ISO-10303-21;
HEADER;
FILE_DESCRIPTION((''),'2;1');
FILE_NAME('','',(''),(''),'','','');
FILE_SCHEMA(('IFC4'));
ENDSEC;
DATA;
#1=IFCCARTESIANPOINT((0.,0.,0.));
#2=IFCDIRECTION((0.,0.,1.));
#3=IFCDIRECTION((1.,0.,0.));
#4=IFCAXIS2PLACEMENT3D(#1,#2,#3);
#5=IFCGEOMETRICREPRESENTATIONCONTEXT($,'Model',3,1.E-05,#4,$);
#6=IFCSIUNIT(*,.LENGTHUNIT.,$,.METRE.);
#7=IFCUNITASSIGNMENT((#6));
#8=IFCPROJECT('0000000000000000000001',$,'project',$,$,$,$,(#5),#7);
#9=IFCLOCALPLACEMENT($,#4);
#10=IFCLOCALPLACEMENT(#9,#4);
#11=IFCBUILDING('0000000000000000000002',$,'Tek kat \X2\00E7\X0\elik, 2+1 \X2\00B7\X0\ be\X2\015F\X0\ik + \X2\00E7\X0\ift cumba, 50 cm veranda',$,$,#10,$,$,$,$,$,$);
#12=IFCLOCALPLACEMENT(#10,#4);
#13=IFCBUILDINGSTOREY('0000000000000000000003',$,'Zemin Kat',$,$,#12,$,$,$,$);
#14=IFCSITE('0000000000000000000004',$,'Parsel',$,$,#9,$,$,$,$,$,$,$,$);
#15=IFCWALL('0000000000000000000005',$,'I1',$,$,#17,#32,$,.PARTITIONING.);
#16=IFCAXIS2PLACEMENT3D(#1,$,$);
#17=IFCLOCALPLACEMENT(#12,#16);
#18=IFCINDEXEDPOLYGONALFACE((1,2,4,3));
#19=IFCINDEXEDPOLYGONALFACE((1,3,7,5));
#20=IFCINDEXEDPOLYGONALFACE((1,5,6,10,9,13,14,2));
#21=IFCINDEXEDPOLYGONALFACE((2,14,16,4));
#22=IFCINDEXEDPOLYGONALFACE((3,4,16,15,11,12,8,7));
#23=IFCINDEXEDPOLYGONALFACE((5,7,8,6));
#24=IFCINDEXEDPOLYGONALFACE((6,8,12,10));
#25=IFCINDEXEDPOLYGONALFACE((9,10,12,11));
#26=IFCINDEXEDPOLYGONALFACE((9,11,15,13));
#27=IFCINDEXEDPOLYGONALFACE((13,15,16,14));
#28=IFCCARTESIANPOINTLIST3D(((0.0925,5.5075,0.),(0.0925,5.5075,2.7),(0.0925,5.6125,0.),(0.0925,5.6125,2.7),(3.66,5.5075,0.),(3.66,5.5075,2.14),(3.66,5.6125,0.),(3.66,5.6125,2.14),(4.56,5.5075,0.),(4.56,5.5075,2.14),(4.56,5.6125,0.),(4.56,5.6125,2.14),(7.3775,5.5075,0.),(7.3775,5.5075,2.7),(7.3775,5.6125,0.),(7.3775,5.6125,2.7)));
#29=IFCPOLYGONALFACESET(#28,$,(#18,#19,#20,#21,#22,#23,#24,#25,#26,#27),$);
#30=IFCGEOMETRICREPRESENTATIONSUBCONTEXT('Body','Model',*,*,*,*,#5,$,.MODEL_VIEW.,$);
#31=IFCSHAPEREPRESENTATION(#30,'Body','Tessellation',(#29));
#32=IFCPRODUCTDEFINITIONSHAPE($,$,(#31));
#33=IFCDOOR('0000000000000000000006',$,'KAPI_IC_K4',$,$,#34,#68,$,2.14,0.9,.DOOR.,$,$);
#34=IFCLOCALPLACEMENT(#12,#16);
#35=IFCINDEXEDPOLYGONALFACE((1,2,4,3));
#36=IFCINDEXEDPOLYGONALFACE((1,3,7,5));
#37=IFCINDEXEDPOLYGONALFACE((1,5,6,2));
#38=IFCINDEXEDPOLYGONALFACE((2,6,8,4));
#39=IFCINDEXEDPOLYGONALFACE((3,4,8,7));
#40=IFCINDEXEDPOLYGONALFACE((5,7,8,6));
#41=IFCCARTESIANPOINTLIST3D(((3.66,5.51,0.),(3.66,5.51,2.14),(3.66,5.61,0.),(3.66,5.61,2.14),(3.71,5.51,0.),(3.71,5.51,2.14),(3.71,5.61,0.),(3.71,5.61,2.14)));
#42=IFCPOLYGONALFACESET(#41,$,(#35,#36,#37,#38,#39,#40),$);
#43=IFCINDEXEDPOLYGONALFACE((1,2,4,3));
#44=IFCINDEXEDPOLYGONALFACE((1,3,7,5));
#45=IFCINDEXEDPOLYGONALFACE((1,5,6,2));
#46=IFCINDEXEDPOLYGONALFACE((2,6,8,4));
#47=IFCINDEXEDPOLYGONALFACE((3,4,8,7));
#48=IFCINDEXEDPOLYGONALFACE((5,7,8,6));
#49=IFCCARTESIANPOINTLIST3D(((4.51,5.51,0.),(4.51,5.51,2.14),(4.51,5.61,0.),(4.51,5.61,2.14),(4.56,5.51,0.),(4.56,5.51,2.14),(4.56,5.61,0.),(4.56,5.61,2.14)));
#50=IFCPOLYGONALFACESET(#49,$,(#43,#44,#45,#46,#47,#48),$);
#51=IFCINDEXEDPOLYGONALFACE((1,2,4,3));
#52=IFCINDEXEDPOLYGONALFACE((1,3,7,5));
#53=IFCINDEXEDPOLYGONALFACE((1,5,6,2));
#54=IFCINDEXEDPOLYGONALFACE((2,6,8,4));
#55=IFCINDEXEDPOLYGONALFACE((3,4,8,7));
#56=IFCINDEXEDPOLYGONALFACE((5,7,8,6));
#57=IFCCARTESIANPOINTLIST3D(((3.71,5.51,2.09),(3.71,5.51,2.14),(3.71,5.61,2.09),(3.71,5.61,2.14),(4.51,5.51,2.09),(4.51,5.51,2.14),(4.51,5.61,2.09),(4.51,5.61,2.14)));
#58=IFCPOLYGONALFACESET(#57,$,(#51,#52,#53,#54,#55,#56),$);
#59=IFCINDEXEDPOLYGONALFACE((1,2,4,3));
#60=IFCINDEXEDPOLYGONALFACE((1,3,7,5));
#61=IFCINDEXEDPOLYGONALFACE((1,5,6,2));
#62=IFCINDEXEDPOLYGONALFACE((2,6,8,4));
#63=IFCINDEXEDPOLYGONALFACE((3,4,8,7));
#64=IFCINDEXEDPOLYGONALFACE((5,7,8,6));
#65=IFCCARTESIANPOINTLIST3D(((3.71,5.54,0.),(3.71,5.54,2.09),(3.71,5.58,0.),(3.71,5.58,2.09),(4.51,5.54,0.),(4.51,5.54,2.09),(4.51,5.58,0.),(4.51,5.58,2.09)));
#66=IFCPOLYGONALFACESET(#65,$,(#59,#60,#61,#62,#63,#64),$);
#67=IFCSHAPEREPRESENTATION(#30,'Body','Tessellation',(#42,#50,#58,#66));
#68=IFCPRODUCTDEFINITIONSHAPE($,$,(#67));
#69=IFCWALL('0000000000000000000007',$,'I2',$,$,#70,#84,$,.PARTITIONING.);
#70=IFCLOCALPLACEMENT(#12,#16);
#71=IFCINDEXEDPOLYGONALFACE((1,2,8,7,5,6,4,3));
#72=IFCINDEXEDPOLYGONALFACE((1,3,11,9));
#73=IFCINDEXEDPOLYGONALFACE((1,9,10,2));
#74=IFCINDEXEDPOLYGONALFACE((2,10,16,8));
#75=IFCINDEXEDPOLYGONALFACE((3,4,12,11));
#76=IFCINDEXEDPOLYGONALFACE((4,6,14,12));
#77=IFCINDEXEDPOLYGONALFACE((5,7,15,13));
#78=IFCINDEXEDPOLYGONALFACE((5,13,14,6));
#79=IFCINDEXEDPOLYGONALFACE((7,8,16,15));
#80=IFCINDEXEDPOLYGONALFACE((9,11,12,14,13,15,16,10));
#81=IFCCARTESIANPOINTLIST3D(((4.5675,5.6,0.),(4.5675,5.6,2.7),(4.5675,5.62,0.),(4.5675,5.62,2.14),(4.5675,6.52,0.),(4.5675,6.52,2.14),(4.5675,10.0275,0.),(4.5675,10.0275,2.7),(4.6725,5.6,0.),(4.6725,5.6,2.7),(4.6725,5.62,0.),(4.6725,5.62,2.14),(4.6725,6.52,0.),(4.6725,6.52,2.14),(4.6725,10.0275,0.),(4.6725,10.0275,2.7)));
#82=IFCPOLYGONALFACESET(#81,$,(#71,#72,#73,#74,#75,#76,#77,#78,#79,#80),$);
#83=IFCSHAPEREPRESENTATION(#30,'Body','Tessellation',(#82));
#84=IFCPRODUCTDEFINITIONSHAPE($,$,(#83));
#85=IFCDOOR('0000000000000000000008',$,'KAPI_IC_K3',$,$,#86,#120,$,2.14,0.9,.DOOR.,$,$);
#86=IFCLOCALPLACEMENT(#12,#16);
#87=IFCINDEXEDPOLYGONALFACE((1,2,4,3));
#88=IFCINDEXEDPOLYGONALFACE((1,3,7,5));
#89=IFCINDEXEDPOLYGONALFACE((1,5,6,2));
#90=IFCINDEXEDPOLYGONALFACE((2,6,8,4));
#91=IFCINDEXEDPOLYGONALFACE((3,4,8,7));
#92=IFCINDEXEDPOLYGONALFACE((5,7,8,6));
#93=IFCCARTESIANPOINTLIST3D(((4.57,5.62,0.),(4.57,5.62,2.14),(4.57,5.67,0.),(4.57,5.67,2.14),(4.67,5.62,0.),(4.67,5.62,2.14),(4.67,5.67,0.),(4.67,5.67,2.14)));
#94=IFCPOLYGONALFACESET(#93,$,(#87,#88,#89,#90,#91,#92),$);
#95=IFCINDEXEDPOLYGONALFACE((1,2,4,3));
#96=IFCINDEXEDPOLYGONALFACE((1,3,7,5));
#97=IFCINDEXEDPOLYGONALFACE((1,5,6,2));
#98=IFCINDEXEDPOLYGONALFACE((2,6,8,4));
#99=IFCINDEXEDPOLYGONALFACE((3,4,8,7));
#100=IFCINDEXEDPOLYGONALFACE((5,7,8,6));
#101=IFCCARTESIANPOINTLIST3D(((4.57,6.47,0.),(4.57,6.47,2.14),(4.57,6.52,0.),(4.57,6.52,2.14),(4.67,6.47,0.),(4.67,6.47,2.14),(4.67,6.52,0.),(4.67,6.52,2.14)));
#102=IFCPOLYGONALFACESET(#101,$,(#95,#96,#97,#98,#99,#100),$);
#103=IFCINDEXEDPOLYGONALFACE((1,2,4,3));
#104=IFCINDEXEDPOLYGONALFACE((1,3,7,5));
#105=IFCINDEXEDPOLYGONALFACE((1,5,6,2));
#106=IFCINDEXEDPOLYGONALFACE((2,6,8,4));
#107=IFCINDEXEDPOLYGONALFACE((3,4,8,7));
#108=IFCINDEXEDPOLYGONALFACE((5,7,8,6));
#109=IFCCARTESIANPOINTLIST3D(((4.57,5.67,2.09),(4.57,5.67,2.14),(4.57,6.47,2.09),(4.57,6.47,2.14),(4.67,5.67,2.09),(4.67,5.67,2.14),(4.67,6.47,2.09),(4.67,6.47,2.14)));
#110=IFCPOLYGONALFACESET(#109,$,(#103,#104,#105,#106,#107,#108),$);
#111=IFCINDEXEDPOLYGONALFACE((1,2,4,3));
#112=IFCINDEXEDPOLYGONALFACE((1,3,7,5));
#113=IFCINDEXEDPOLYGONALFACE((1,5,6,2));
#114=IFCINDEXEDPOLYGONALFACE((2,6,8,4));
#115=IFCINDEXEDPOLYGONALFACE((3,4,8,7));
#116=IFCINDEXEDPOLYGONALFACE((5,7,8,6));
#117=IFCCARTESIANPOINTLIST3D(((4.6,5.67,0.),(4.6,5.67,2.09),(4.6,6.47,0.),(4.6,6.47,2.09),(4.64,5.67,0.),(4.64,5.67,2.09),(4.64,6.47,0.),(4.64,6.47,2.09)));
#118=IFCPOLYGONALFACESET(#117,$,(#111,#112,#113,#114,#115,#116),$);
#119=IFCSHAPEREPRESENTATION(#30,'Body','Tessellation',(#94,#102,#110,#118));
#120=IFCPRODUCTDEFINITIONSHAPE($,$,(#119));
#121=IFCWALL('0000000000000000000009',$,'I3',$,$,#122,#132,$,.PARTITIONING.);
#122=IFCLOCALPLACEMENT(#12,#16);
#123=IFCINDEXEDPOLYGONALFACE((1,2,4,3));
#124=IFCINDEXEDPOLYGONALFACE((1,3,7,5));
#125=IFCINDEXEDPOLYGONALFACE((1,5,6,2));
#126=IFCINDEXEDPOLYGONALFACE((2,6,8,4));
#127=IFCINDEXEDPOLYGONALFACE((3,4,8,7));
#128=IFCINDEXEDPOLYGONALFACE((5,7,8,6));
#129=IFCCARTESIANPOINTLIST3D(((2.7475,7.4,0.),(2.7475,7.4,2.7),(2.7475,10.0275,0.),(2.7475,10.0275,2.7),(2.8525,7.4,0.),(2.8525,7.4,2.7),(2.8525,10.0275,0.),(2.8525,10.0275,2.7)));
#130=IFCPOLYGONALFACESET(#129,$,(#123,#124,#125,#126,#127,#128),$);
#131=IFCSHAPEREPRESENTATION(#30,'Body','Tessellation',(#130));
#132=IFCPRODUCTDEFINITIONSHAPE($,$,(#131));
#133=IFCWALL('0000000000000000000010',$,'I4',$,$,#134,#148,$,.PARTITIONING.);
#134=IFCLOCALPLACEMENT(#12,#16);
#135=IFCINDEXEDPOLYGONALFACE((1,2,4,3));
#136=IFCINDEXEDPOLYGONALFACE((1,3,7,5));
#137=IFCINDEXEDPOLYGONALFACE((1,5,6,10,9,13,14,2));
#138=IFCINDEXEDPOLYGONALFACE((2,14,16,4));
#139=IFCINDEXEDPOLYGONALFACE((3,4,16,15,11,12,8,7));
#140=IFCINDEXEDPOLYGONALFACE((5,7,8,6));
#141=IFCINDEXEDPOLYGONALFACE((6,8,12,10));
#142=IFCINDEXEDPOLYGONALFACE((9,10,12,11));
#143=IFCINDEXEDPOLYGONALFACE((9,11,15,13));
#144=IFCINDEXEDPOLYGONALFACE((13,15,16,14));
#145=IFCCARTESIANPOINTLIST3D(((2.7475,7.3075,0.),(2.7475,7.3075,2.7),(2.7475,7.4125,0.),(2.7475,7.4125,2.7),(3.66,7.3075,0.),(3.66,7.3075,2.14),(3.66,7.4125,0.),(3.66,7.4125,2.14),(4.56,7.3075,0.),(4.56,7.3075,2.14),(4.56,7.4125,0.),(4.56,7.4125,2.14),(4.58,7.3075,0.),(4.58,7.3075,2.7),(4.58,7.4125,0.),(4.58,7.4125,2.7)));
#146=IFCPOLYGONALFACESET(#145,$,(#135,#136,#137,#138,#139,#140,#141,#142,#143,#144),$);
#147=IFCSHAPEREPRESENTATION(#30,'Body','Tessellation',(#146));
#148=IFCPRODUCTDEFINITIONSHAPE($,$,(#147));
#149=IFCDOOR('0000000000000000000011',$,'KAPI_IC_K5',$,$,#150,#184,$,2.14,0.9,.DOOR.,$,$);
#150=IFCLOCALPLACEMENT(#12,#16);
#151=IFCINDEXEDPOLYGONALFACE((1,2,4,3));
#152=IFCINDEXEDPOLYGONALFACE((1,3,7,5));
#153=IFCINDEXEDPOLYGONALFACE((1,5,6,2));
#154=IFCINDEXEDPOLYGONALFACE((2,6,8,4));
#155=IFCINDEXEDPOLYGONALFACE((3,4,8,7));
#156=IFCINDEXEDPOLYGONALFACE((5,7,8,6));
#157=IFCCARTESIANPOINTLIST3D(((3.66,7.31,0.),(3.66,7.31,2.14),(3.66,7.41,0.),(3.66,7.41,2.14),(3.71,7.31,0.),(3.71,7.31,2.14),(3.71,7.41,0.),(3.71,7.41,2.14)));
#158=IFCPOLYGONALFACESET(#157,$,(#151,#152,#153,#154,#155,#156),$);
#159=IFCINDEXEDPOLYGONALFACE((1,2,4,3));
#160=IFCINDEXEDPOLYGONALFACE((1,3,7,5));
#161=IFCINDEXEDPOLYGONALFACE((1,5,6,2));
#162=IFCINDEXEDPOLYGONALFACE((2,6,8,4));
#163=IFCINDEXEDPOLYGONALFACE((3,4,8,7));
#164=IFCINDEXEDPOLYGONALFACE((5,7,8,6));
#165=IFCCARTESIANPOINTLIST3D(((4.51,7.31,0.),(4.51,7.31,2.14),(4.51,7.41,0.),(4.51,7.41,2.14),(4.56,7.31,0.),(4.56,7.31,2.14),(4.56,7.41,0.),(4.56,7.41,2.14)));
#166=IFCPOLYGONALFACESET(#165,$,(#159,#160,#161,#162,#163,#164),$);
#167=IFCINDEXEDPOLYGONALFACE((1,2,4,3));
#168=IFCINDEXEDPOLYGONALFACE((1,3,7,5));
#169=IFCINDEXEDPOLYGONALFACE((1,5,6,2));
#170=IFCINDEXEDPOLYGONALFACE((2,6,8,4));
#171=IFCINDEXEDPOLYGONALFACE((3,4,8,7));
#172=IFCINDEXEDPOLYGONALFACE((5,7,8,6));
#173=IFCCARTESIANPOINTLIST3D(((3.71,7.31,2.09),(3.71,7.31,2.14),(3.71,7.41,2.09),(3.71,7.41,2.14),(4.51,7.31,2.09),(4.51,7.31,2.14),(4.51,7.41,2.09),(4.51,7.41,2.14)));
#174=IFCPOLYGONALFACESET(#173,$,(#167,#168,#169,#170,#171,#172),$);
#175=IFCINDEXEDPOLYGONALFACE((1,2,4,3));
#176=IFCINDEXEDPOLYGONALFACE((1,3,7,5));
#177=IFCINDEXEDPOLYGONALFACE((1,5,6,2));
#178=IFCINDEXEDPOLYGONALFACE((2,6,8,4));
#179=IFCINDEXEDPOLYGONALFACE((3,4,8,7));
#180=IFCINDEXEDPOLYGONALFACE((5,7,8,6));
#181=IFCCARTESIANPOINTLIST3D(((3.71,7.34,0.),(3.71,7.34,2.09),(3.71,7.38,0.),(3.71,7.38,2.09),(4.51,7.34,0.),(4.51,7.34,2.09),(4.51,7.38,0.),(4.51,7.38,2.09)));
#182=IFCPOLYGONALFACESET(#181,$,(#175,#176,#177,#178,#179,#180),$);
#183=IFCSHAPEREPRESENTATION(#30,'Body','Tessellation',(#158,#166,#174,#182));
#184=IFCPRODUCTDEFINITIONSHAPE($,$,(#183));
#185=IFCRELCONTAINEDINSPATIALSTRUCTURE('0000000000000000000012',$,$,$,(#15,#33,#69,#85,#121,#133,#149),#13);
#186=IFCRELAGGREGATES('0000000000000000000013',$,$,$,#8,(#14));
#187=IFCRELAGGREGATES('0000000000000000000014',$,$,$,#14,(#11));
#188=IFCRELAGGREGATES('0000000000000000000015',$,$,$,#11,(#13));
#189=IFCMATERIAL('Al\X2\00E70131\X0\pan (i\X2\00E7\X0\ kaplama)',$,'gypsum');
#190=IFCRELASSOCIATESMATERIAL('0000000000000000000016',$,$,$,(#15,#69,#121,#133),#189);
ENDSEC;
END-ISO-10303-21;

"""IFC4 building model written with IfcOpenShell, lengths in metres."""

from ifc_helpers import new_model, si_unit, frame, origin_with_axes, place, context, subcontext, project, spatial, line, indexed_curve, outline, extrude, material, element, fill, save


model = new_model("IFC4")

# Units and contexts
model_context = context("Model", 3, precision=1e-05, world=origin_with_axes())
body_context = subcontext(model_context, "Body", "Model", "MODEL_VIEW")
ifc_project = project(units=[si_unit("LENGTHUNIT", "METRE")], contexts=[model_context])

# Site, building, storey
site_placement = place(None, origin_with_axes())
site = spatial("IfcSite", under=ifc_project, at=site_placement, Name="Parsel")
building_placement = place(site_placement, origin_with_axes())
building = spatial("IfcBuilding", under=site, at=building_placement, Name="Tek kat çelik, 2+1 · beşik + çift cumba, 50 cm veranda")
storey_placement = place(building_placement, origin_with_axes())
storey = spatial("IfcBuildingStorey", under=building, at=storey_placement, Name="Zemin Kat")

# Walls, openings, doors
ifc_material_1 = material(Name="Alçıpan (iç kaplama)", Category="gypsum")
wall_1_placement = place(storey_placement, origin_with_axes())
wall_1 = element("IfcWall", 1, at=wall_1_placement, inside=storey, material=ifc_material_1, Name="I1", PredefinedType="PARTITIONING", context=body_context, shape_type="SweptSolid", body=[
    extrude(outline(indexed_curve([(0.0, 0.0), (7.285, 0.0), (7.285, 0.105), (0.0, 0.105)], segments=[line(1, 2, 3, 4, 1)])), frame((0.0925, 5.5075, 0.0), z_axis=(0.0, 0.0, 1.0), x_axis=(1.0, 0.0, 0.0)), (0.0, 0.0, 1.0), 2.7),
])
opening_1_placement = place(wall_1_placement, origin_with_axes())
opening_1 = element("IfcOpeningElement", 2, at=opening_1_placement, cuts=wall_1, PredefinedType="OPENING", context=body_context, shape_type="SweptSolid", body=[
    extrude(outline(indexed_curve([(0.0, 0.0), (0.9, 0.0), (0.9, 0.145), (0.0, 0.145)], segments=[line(1, 2, 3, 4, 1)])), frame((3.66, 5.4875, 0.0), z_axis=(0.0, 0.0, 1.0), x_axis=(1.0, 0.0, 0.0)), (0.0, 0.0, 1.0), 2.14),
])
door_1_placement = place(storey_placement, origin_with_axes())
door_1 = element("IfcDoor", 3, at=door_1_placement, inside=storey, Name="KAPI_IC_K4", OverallHeight=2.14, OverallWidth=0.9, PredefinedType="DOOR", context=body_context, shape_type="SweptSolid", body=[
    extrude(outline(indexed_curve([(0.0, 0.0), (0.05, 0.0), (0.05, 0.1), (0.0, 0.1)], segments=[line(1, 2, 3, 4, 1)])), frame((3.66, 5.51, 0.0), z_axis=(0.0, 0.0, 1.0), x_axis=(1.0, 0.0, 0.0)), (0.0, 0.0, 1.0), 2.14),
    extrude(outline(indexed_curve([(0.0, 0.0), (0.05, 0.0), (0.05, 0.1), (0.0, 0.1)], segments=[line(1, 2, 3, 4, 1)])), frame((4.51, 5.51, 0.0), z_axis=(0.0, 0.0, 1.0), x_axis=(1.0, 0.0, 0.0)), (0.0, 0.0, 1.0), 2.14),
    extrude(outline(indexed_curve([(0.0, 0.0), (0.8, 0.0), (0.8, 0.1), (0.0, 0.1)], segments=[line(1, 2, 3, 4, 1)])), frame((3.71, 5.51, 2.09), z_axis=(0.0, 0.0, 1.0), x_axis=(1.0, 0.0, 0.0)), (0.0, 0.0, 1.0), 0.05),
    extrude(outline(indexed_curve([(0.0, 0.0), (0.8, 0.0), (0.8, 0.04), (0.0, 0.04)], segments=[line(1, 2, 3, 4, 1)])), frame((3.71, 5.54, 0.0), z_axis=(0.0, 0.0, 1.0), x_axis=(1.0, 0.0, 0.0)), (0.0, 0.0, 1.0), 2.09),
])
fill(opening_1, door_1)
wall_2_placement = place(storey_placement, origin_with_axes())
wall_2 = element("IfcWall", 4, at=wall_2_placement, inside=storey, material=ifc_material_1, Name="I2", PredefinedType="PARTITIONING", context=body_context, shape_type="SweptSolid", body=[
    extrude(outline(indexed_curve([(0.0, 0.0), (0.105, 0.0), (0.105, 4.4275), (0.0, 4.4275)], segments=[line(1, 2, 3, 4, 1)])), frame((4.5675, 5.6, 0.0), z_axis=(0.0, 0.0, 1.0), x_axis=(1.0, 0.0, 0.0)), (0.0, 0.0, 1.0), 2.7),
])
opening_2_placement = place(wall_2_placement, origin_with_axes())
opening_2 = element("IfcOpeningElement", 5, at=opening_2_placement, cuts=wall_2, PredefinedType="OPENING", context=body_context, shape_type="SweptSolid", body=[
    extrude(outline(indexed_curve([(0.0, 0.0), (0.145, 0.0), (0.145, 0.9), (0.0, 0.9)], segments=[line(1, 2, 3, 4, 1)])), frame((4.5475, 5.62, 0.0), z_axis=(0.0, 0.0, 1.0), x_axis=(1.0, 0.0, 0.0)), (0.0, 0.0, 1.0), 2.14),
])
door_2_placement = place(storey_placement, origin_with_axes())
door_2 = element("IfcDoor", 6, at=door_2_placement, inside=storey, Name="KAPI_IC_K3", OverallHeight=2.14, OverallWidth=0.9, PredefinedType="DOOR", context=body_context, shape_type="SweptSolid", body=[
    extrude(outline(indexed_curve([(0.0, 0.0), (0.1, 0.0), (0.1, 0.05), (0.0, 0.05)], segments=[line(1, 2, 3, 4, 1)])), frame((4.57, 5.62, 0.0), z_axis=(0.0, 0.0, 1.0), x_axis=(1.0, 0.0, 0.0)), (0.0, 0.0, 1.0), 2.14),
    extrude(outline(indexed_curve([(0.0, 0.0), (0.1, 0.0), (0.1, 0.05), (0.0, 0.05)], segments=[line(1, 2, 3, 4, 1)])), frame((4.57, 6.47, 0.0), z_axis=(0.0, 0.0, 1.0), x_axis=(1.0, 0.0, 0.0)), (0.0, 0.0, 1.0), 2.14),
    extrude(outline(indexed_curve([(0.0, 0.0), (0.1, 0.0), (0.1, 0.8), (0.0, 0.8)], segments=[line(1, 2, 3, 4, 1)])), frame((4.57, 5.67, 2.09), z_axis=(0.0, 0.0, 1.0), x_axis=(1.0, 0.0, 0.0)), (0.0, 0.0, 1.0), 0.05),
    extrude(outline(indexed_curve([(0.0, 0.0), (0.04, 0.0), (0.04, 0.8), (0.0, 0.8)], segments=[line(1, 2, 3, 4, 1)])), frame((4.6, 5.67, 0.0), z_axis=(0.0, 0.0, 1.0), x_axis=(1.0, 0.0, 0.0)), (0.0, 0.0, 1.0), 2.09),
])
fill(opening_2, door_2)

# Wall
wall_3_placement = place(storey_placement, origin_with_axes())
element("IfcWall", 7, at=wall_3_placement, inside=storey, material=ifc_material_1, Name="I3", PredefinedType="PARTITIONING", context=body_context, shape_type="SweptSolid", body=[
    extrude(outline(indexed_curve([(0.0, 0.0), (0.105, 0.0), (0.105, 2.6275), (0.0, 2.6275)], segments=[line(1, 2, 3, 4, 1)])), frame((2.7475, 7.4, 0.0), z_axis=(0.0, 0.0, 1.0), x_axis=(1.0, 0.0, 0.0)), (0.0, 0.0, 1.0), 2.7),
])

# Wall, opening, door
wall_4_placement = place(storey_placement, origin_with_axes())
wall_4 = element("IfcWall", 8, at=wall_4_placement, inside=storey, material=ifc_material_1, Name="I4", PredefinedType="PARTITIONING", context=body_context, shape_type="SweptSolid", body=[
    extrude(outline(indexed_curve([(0.0, 0.0), (1.8325, 0.0), (1.8325, 0.105), (0.0, 0.105)], segments=[line(1, 2, 3, 4, 1)])), frame((2.7475, 7.3075, 0.0), z_axis=(0.0, 0.0, 1.0), x_axis=(1.0, 0.0, 0.0)), (0.0, 0.0, 1.0), 2.7),
])
opening_3_placement = place(wall_4_placement, origin_with_axes())
opening_3 = element("IfcOpeningElement", 9, at=opening_3_placement, cuts=wall_4, PredefinedType="OPENING", context=body_context, shape_type="SweptSolid", body=[
    extrude(outline(indexed_curve([(0.0, 0.0), (0.9, 0.0), (0.9, 0.145), (0.0, 0.145)], segments=[line(1, 2, 3, 4, 1)])), frame((3.66, 7.2875, 0.0), z_axis=(0.0, 0.0, 1.0), x_axis=(1.0, 0.0, 0.0)), (0.0, 0.0, 1.0), 2.14),
])
door_3_placement = place(storey_placement, origin_with_axes())
door_3 = element("IfcDoor", 10, at=door_3_placement, inside=storey, Name="KAPI_IC_K5", OverallHeight=2.14, OverallWidth=0.9, PredefinedType="DOOR", context=body_context, shape_type="SweptSolid", body=[
    extrude(outline(indexed_curve([(0.0, 0.0), (0.05, 0.0), (0.05, 0.1), (0.0, 0.1)], segments=[line(1, 2, 3, 4, 1)])), frame((3.66, 7.31, 0.0), z_axis=(0.0, 0.0, 1.0), x_axis=(1.0, 0.0, 0.0)), (0.0, 0.0, 1.0), 2.14),
    extrude(outline(indexed_curve([(0.0, 0.0), (0.05, 0.0), (0.05, 0.1), (0.0, 0.1)], segments=[line(1, 2, 3, 4, 1)])), frame((4.51, 7.31, 0.0), z_axis=(0.0, 0.0, 1.0), x_axis=(1.0, 0.0, 0.0)), (0.0, 0.0, 1.0), 2.14),
    extrude(outline(indexed_curve([(0.0, 0.0), (0.8, 0.0), (0.8, 0.1), (0.0, 0.1)], segments=[line(1, 2, 3, 4, 1)])), frame((3.71, 7.31, 2.09), z_axis=(0.0, 0.0, 1.0), x_axis=(1.0, 0.0, 0.0)), (0.0, 0.0, 1.0), 0.05),
    extrude(outline(indexed_curve([(0.0, 0.0), (0.8, 0.0), (0.8, 0.04), (0.0, 0.04)], segments=[line(1, 2, 3, 4, 1)])), frame((3.71, 7.34, 0.0), z_axis=(0.0, 0.0, 1.0), x_axis=(1.0, 0.0, 0.0)), (0.0, 0.0, 1.0), 2.09),
])
fill(opening_3, door_3)

save(model, "model.ifc")
